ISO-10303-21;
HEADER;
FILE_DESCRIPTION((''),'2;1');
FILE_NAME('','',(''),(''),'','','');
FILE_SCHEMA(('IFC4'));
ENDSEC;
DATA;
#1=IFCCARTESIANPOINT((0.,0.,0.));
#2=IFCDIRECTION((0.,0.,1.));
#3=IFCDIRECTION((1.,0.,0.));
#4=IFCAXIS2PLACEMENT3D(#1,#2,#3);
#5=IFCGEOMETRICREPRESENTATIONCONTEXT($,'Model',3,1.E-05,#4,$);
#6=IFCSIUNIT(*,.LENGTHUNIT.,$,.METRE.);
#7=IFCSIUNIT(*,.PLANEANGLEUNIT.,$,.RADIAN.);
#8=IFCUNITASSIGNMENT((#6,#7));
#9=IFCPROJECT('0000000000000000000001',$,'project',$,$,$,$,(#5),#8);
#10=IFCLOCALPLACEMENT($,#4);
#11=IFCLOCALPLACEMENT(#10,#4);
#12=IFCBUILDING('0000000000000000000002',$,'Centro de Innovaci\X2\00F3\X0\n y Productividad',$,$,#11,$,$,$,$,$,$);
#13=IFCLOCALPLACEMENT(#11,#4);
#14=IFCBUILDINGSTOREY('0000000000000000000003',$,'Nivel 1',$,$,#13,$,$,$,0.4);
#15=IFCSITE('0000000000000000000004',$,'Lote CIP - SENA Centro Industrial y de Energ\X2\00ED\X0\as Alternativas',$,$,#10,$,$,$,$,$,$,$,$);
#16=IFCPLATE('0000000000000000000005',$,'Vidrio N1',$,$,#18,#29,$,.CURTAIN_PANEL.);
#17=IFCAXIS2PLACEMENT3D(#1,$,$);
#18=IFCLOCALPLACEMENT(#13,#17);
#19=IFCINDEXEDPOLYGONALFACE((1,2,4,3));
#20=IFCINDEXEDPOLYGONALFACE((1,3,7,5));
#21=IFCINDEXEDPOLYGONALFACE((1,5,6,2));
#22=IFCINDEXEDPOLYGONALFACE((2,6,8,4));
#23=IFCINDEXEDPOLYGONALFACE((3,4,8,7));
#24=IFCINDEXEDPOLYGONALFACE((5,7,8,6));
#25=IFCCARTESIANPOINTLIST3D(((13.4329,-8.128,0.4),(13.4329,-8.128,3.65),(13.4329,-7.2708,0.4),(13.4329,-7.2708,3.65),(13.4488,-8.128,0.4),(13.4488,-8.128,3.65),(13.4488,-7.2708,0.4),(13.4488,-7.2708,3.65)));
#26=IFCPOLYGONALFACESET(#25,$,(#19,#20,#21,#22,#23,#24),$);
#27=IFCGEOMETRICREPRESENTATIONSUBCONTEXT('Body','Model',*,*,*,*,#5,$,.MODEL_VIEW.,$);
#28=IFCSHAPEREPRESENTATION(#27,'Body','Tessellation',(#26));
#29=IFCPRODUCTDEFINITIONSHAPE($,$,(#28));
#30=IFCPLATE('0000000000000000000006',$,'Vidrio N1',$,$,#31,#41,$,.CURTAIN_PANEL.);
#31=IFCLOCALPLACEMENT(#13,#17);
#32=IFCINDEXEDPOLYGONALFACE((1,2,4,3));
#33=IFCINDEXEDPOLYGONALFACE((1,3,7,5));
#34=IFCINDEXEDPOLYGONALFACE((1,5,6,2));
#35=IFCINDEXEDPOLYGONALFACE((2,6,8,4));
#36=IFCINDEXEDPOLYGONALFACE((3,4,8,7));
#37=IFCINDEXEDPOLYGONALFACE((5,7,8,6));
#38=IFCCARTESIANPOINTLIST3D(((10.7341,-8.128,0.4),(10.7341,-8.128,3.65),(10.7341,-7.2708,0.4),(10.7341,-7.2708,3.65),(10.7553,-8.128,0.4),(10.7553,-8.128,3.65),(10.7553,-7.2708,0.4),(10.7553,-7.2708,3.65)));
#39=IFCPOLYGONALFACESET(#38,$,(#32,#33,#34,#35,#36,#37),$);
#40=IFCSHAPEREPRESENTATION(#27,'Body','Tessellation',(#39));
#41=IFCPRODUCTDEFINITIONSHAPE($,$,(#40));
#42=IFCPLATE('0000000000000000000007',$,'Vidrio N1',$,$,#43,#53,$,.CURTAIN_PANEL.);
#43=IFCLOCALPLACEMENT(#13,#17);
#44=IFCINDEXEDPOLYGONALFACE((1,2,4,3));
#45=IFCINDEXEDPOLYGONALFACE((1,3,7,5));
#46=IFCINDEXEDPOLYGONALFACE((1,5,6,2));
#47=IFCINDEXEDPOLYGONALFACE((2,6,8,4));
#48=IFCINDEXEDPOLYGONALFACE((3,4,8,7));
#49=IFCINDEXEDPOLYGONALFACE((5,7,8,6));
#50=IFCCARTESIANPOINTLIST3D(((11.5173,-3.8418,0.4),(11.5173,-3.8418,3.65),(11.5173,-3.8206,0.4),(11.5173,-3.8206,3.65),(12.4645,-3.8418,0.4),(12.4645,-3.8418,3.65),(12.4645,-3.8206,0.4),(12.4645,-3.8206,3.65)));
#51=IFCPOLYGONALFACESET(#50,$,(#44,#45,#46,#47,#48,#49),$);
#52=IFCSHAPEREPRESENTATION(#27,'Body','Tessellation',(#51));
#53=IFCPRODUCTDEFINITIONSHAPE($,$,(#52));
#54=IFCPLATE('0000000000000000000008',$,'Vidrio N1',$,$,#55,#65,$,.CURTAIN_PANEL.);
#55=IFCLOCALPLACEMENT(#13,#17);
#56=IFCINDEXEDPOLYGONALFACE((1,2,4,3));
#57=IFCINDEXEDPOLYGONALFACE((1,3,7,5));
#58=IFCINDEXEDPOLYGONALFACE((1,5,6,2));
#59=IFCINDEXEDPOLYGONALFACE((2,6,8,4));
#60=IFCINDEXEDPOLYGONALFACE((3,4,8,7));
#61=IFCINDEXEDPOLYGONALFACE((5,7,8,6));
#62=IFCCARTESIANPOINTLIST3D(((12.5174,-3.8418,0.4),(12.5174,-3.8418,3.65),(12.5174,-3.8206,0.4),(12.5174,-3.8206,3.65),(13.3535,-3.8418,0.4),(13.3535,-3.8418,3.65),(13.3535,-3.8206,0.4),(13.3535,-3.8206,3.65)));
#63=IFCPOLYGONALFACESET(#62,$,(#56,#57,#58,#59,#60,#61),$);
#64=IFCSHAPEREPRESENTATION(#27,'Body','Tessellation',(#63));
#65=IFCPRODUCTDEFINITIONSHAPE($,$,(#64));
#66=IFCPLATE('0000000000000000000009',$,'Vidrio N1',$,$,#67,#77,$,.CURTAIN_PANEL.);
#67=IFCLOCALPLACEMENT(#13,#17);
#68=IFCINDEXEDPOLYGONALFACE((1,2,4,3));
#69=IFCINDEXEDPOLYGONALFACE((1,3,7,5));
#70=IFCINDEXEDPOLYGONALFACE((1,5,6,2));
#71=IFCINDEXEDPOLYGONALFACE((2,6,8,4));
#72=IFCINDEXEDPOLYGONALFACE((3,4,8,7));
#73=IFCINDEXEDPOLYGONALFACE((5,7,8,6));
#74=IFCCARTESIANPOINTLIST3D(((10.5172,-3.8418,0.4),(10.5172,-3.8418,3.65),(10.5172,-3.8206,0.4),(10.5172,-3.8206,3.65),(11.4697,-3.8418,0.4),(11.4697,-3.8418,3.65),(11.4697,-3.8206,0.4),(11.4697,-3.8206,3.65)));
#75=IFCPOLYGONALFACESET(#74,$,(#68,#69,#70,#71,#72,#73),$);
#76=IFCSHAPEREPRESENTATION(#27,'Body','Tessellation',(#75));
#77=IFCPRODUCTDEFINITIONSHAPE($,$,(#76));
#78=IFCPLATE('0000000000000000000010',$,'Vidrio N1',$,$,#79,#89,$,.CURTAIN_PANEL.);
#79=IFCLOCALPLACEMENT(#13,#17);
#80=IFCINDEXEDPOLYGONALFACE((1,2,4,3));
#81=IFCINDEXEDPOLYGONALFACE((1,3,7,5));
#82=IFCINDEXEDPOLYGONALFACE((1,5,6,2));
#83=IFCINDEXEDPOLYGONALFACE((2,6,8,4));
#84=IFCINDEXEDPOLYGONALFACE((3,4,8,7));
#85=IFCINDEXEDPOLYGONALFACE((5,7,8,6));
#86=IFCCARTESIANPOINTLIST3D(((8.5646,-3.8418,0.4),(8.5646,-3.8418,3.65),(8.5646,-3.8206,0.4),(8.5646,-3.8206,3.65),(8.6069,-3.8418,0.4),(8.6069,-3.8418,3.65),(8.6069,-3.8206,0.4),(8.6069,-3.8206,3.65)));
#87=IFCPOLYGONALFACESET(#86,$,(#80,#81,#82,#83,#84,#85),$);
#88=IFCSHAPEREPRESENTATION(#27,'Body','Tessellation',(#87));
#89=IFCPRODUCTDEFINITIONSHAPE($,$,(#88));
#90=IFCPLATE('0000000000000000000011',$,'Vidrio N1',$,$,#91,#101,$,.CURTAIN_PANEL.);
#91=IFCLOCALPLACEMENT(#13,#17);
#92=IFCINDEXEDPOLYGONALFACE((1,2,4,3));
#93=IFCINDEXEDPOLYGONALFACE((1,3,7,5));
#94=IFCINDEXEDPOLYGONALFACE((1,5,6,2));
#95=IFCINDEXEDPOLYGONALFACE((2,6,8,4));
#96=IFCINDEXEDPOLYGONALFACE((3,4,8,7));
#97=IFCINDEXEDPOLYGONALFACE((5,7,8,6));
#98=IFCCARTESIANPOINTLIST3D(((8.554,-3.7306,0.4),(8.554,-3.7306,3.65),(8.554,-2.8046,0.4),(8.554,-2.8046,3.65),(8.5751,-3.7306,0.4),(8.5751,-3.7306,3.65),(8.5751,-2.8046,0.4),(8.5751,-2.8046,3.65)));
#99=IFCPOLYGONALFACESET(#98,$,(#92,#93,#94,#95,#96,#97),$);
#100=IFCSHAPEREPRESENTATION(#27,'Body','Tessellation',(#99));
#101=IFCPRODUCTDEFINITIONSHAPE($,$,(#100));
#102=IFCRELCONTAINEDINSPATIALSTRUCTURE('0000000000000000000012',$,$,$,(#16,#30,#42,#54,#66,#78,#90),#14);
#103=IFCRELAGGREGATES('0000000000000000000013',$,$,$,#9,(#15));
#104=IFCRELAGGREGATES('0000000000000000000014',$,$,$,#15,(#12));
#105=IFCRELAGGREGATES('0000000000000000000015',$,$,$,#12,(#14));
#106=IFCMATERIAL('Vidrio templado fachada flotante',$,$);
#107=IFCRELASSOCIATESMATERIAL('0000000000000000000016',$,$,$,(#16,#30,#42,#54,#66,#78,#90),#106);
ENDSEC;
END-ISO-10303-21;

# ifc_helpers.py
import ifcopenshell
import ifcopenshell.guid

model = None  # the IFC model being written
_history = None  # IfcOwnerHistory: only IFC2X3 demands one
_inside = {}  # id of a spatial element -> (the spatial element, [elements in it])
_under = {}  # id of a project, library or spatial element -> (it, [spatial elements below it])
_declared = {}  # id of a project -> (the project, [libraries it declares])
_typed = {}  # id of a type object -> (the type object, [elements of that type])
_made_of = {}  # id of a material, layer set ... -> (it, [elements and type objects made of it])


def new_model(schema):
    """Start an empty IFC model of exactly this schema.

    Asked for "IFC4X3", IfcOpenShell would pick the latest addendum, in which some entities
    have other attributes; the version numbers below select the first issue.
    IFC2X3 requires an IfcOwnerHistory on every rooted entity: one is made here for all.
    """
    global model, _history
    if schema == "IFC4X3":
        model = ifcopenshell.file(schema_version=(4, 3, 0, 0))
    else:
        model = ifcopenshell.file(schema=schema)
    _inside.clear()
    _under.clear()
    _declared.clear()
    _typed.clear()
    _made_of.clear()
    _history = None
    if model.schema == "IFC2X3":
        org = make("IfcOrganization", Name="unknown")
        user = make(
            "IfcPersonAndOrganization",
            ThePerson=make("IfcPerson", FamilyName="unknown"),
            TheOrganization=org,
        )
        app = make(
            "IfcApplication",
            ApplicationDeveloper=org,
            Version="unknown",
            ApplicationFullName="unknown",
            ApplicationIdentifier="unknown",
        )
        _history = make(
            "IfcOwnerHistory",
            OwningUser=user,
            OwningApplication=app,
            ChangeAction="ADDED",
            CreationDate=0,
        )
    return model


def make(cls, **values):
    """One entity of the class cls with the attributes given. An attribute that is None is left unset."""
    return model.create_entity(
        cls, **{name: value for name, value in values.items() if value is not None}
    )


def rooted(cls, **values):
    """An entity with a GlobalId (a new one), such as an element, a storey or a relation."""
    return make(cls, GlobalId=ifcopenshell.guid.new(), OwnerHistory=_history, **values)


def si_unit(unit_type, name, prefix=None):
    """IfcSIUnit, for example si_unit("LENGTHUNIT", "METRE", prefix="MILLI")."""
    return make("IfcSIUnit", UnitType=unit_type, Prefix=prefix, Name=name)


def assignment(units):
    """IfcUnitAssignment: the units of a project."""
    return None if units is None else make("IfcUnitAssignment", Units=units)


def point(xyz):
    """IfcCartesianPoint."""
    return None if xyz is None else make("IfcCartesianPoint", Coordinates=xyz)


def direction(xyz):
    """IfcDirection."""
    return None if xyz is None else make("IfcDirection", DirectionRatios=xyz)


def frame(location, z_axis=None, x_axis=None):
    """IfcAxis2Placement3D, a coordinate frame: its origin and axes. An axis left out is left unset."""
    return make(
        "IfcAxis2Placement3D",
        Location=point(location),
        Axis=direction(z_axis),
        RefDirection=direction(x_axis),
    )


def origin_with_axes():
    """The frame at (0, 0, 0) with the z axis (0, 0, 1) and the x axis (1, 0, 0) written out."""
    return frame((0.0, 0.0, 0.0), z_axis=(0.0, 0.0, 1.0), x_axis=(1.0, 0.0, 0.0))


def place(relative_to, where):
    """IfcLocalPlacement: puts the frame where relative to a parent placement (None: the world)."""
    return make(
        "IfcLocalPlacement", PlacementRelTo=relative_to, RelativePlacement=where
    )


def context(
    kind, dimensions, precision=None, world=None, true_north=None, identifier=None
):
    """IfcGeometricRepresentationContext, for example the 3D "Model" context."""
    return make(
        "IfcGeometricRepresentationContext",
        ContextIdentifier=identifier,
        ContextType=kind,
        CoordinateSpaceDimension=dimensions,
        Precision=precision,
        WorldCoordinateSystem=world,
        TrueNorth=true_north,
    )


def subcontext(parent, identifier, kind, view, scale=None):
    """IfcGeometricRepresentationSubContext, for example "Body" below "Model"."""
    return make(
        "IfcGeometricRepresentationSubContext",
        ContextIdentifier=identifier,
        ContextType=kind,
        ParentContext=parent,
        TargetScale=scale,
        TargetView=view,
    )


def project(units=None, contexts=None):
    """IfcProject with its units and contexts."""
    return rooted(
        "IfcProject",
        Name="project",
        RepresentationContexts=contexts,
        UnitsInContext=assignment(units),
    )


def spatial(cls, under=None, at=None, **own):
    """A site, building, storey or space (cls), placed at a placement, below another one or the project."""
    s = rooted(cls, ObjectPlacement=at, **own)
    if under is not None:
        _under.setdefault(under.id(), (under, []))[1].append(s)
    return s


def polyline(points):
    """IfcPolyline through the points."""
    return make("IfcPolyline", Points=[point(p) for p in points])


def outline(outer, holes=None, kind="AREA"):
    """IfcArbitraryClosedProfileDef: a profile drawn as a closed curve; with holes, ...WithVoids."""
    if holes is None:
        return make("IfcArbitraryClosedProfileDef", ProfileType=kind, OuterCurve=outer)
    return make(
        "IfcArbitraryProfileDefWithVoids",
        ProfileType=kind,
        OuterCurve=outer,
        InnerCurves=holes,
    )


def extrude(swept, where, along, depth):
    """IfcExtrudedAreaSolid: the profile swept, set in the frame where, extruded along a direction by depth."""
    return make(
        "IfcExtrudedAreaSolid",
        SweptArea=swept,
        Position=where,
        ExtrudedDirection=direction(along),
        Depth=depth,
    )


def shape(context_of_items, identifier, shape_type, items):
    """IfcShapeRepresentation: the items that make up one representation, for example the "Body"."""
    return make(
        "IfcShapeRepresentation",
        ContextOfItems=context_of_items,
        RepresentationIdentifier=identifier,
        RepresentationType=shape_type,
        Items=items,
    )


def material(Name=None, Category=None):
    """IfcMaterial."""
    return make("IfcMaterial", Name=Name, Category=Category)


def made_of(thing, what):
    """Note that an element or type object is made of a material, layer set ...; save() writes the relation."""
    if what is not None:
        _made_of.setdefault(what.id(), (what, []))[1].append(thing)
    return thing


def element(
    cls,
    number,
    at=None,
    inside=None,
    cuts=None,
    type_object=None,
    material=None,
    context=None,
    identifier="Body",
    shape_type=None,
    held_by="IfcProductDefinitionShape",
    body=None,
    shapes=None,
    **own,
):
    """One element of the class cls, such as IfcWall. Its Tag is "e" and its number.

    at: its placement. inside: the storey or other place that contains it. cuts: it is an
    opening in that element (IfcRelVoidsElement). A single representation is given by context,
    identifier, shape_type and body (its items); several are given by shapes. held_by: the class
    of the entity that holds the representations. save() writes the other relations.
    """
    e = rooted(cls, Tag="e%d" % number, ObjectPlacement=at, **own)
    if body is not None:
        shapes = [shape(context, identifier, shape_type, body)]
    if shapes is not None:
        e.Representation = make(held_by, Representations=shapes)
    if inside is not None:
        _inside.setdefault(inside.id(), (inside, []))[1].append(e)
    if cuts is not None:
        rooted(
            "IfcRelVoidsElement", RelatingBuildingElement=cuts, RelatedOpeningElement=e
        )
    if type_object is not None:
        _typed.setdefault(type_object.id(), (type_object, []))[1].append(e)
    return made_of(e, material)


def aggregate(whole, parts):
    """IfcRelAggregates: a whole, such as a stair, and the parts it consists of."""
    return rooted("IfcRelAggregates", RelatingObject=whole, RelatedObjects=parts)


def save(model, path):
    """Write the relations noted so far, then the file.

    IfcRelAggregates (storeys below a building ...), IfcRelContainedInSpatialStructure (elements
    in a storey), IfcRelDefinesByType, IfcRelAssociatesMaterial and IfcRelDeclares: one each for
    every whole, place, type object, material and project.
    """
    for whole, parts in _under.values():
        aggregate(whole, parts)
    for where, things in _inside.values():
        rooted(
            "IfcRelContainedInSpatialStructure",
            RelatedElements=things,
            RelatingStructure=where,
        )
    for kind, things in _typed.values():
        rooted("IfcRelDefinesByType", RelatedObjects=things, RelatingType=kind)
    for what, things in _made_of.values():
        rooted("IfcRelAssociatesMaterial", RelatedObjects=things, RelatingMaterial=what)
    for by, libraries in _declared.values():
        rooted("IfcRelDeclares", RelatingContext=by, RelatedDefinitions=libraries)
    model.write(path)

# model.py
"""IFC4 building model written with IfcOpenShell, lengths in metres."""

from ifc_helpers import new_model, si_unit, frame, origin_with_axes, place, context, subcontext, project, spatial, polyline, outline, extrude, material, element, save


model = new_model("IFC4")

# Units and contexts
model_context = context("Model", 3, precision=1e-05, world=origin_with_axes())
body_context = subcontext(model_context, "Body", "Model", "MODEL_VIEW")
ifc_project = project(units=[si_unit("LENGTHUNIT", "METRE"), si_unit("PLANEANGLEUNIT", "RADIAN")], contexts=[model_context])

# Site, building, storey
site_placement = place(None, origin_with_axes())
site = spatial("IfcSite", under=ifc_project, at=site_placement, Name="Lote CIP - SENA Centro Industrial y de Energías Alternativas")
building_placement = place(site_placement, origin_with_axes())
building = spatial("IfcBuilding", under=site, at=building_placement, Name="Centro de Innovación y Productividad")
storey_placement = place(building_placement, origin_with_axes())
storey = spatial("IfcBuildingStorey", under=building, at=storey_placement, Name="Nivel 1", Elevation=0.4)

# Plates
ifc_material = material(Name="Vidrio templado fachada flotante")
plate_1_placement = place(storey_placement, origin_with_axes())
element("IfcPlate", 1, at=plate_1_placement, inside=storey, material=ifc_material, Name="Vidrio N1", PredefinedType="CURTAIN_PANEL", context=body_context, shape_type="SweptSolid", body=[
    extrude(outline(polyline([(13.4488, -7.2708), (13.4488, -8.128), (13.4329, -8.128), (13.4329, -7.2708), (13.4488, -7.2708)])), frame((0.0, 0.0, 0.4)), (0.0, 0.0, 1.0), 3.25),
])
plate_2_placement = place(storey_placement, origin_with_axes())
element("IfcPlate", 2, at=plate_2_placement, inside=storey, material=ifc_material, Name="Vidrio N1", PredefinedType="CURTAIN_PANEL", context=body_context, shape_type="SweptSolid", body=[
    extrude(outline(polyline([(10.7553, -8.128), (10.7341, -8.128), (10.7341, -7.2708), (10.7553, -7.2708), (10.7553, -8.128)])), frame((0.0, 0.0, 0.4)), (0.0, 0.0, 1.0), 3.25),
])
plate_3_placement = place(storey_placement, origin_with_axes())
element("IfcPlate", 3, at=plate_3_placement, inside=storey, material=ifc_material, Name="Vidrio N1", PredefinedType="CURTAIN_PANEL", context=body_context, shape_type="SweptSolid", body=[
    extrude(outline(polyline([(12.4645, -3.8206), (12.4645, -3.8417), (11.5173, -3.8417), (11.5173, -3.8206), (12.4645, -3.8206)])), frame((0.0, 0.0, 0.4)), (0.0, 0.0, 1.0), 3.25),
])
plate_4_placement = place(storey_placement, origin_with_axes())
element("IfcPlate", 4, at=plate_4_placement, inside=storey, material=ifc_material, Name="Vidrio N1", PredefinedType="CURTAIN_PANEL", context=body_context, shape_type="SweptSolid", body=[
    extrude(outline(polyline([(12.5174, -3.8417), (12.5174, -3.8206), (13.3535, -3.8206), (13.3535, -3.8417), (12.5174, -3.8417)])), frame((0.0, 0.0, 0.4)), (0.0, 0.0, 1.0), 3.25),
])
plate_5_placement = place(storey_placement, origin_with_axes())
element("IfcPlate", 5, at=plate_5_placement, inside=storey, material=ifc_material, Name="Vidrio N1", PredefinedType="CURTAIN_PANEL", context=body_context, shape_type="SweptSolid", body=[
    extrude(outline(polyline([(11.4697, -3.8417), (10.5172, -3.8417), (10.5172, -3.8206), (11.4697, -3.8206), (11.4697, -3.8417)])), frame((0.0, 0.0, 0.4)), (0.0, 0.0, 1.0), 3.25),
])
plate_6_placement = place(storey_placement, origin_with_axes())
element("IfcPlate", 6, at=plate_6_placement, inside=storey, material=ifc_material, Name="Vidrio N1", PredefinedType="CURTAIN_PANEL", context=body_context, shape_type="SweptSolid", body=[
    extrude(outline(polyline([(8.6069, -3.8206), (8.6069, -3.8417), (8.5646, -3.8417), (8.5646, -3.8206), (8.6069, -3.8206)])), frame((0.0, 0.0, 0.4)), (0.0, 0.0, 1.0), 3.25),
])
plate_7_placement = place(storey_placement, origin_with_axes())
element("IfcPlate", 7, at=plate_7_placement, inside=storey, material=ifc_material, Name="Vidrio N1", PredefinedType="CURTAIN_PANEL", context=body_context, shape_type="SweptSolid", body=[
    extrude(outline(polyline([(8.5751, -3.7306), (8.554, -3.7306), (8.554, -2.8046), (8.5751, -2.8046), (8.5751, -3.7306)])), frame((0.0, 0.0, 0.4)), (0.0, 0.0, 1.0), 3.25),
])

save(model, "model.ifc")
